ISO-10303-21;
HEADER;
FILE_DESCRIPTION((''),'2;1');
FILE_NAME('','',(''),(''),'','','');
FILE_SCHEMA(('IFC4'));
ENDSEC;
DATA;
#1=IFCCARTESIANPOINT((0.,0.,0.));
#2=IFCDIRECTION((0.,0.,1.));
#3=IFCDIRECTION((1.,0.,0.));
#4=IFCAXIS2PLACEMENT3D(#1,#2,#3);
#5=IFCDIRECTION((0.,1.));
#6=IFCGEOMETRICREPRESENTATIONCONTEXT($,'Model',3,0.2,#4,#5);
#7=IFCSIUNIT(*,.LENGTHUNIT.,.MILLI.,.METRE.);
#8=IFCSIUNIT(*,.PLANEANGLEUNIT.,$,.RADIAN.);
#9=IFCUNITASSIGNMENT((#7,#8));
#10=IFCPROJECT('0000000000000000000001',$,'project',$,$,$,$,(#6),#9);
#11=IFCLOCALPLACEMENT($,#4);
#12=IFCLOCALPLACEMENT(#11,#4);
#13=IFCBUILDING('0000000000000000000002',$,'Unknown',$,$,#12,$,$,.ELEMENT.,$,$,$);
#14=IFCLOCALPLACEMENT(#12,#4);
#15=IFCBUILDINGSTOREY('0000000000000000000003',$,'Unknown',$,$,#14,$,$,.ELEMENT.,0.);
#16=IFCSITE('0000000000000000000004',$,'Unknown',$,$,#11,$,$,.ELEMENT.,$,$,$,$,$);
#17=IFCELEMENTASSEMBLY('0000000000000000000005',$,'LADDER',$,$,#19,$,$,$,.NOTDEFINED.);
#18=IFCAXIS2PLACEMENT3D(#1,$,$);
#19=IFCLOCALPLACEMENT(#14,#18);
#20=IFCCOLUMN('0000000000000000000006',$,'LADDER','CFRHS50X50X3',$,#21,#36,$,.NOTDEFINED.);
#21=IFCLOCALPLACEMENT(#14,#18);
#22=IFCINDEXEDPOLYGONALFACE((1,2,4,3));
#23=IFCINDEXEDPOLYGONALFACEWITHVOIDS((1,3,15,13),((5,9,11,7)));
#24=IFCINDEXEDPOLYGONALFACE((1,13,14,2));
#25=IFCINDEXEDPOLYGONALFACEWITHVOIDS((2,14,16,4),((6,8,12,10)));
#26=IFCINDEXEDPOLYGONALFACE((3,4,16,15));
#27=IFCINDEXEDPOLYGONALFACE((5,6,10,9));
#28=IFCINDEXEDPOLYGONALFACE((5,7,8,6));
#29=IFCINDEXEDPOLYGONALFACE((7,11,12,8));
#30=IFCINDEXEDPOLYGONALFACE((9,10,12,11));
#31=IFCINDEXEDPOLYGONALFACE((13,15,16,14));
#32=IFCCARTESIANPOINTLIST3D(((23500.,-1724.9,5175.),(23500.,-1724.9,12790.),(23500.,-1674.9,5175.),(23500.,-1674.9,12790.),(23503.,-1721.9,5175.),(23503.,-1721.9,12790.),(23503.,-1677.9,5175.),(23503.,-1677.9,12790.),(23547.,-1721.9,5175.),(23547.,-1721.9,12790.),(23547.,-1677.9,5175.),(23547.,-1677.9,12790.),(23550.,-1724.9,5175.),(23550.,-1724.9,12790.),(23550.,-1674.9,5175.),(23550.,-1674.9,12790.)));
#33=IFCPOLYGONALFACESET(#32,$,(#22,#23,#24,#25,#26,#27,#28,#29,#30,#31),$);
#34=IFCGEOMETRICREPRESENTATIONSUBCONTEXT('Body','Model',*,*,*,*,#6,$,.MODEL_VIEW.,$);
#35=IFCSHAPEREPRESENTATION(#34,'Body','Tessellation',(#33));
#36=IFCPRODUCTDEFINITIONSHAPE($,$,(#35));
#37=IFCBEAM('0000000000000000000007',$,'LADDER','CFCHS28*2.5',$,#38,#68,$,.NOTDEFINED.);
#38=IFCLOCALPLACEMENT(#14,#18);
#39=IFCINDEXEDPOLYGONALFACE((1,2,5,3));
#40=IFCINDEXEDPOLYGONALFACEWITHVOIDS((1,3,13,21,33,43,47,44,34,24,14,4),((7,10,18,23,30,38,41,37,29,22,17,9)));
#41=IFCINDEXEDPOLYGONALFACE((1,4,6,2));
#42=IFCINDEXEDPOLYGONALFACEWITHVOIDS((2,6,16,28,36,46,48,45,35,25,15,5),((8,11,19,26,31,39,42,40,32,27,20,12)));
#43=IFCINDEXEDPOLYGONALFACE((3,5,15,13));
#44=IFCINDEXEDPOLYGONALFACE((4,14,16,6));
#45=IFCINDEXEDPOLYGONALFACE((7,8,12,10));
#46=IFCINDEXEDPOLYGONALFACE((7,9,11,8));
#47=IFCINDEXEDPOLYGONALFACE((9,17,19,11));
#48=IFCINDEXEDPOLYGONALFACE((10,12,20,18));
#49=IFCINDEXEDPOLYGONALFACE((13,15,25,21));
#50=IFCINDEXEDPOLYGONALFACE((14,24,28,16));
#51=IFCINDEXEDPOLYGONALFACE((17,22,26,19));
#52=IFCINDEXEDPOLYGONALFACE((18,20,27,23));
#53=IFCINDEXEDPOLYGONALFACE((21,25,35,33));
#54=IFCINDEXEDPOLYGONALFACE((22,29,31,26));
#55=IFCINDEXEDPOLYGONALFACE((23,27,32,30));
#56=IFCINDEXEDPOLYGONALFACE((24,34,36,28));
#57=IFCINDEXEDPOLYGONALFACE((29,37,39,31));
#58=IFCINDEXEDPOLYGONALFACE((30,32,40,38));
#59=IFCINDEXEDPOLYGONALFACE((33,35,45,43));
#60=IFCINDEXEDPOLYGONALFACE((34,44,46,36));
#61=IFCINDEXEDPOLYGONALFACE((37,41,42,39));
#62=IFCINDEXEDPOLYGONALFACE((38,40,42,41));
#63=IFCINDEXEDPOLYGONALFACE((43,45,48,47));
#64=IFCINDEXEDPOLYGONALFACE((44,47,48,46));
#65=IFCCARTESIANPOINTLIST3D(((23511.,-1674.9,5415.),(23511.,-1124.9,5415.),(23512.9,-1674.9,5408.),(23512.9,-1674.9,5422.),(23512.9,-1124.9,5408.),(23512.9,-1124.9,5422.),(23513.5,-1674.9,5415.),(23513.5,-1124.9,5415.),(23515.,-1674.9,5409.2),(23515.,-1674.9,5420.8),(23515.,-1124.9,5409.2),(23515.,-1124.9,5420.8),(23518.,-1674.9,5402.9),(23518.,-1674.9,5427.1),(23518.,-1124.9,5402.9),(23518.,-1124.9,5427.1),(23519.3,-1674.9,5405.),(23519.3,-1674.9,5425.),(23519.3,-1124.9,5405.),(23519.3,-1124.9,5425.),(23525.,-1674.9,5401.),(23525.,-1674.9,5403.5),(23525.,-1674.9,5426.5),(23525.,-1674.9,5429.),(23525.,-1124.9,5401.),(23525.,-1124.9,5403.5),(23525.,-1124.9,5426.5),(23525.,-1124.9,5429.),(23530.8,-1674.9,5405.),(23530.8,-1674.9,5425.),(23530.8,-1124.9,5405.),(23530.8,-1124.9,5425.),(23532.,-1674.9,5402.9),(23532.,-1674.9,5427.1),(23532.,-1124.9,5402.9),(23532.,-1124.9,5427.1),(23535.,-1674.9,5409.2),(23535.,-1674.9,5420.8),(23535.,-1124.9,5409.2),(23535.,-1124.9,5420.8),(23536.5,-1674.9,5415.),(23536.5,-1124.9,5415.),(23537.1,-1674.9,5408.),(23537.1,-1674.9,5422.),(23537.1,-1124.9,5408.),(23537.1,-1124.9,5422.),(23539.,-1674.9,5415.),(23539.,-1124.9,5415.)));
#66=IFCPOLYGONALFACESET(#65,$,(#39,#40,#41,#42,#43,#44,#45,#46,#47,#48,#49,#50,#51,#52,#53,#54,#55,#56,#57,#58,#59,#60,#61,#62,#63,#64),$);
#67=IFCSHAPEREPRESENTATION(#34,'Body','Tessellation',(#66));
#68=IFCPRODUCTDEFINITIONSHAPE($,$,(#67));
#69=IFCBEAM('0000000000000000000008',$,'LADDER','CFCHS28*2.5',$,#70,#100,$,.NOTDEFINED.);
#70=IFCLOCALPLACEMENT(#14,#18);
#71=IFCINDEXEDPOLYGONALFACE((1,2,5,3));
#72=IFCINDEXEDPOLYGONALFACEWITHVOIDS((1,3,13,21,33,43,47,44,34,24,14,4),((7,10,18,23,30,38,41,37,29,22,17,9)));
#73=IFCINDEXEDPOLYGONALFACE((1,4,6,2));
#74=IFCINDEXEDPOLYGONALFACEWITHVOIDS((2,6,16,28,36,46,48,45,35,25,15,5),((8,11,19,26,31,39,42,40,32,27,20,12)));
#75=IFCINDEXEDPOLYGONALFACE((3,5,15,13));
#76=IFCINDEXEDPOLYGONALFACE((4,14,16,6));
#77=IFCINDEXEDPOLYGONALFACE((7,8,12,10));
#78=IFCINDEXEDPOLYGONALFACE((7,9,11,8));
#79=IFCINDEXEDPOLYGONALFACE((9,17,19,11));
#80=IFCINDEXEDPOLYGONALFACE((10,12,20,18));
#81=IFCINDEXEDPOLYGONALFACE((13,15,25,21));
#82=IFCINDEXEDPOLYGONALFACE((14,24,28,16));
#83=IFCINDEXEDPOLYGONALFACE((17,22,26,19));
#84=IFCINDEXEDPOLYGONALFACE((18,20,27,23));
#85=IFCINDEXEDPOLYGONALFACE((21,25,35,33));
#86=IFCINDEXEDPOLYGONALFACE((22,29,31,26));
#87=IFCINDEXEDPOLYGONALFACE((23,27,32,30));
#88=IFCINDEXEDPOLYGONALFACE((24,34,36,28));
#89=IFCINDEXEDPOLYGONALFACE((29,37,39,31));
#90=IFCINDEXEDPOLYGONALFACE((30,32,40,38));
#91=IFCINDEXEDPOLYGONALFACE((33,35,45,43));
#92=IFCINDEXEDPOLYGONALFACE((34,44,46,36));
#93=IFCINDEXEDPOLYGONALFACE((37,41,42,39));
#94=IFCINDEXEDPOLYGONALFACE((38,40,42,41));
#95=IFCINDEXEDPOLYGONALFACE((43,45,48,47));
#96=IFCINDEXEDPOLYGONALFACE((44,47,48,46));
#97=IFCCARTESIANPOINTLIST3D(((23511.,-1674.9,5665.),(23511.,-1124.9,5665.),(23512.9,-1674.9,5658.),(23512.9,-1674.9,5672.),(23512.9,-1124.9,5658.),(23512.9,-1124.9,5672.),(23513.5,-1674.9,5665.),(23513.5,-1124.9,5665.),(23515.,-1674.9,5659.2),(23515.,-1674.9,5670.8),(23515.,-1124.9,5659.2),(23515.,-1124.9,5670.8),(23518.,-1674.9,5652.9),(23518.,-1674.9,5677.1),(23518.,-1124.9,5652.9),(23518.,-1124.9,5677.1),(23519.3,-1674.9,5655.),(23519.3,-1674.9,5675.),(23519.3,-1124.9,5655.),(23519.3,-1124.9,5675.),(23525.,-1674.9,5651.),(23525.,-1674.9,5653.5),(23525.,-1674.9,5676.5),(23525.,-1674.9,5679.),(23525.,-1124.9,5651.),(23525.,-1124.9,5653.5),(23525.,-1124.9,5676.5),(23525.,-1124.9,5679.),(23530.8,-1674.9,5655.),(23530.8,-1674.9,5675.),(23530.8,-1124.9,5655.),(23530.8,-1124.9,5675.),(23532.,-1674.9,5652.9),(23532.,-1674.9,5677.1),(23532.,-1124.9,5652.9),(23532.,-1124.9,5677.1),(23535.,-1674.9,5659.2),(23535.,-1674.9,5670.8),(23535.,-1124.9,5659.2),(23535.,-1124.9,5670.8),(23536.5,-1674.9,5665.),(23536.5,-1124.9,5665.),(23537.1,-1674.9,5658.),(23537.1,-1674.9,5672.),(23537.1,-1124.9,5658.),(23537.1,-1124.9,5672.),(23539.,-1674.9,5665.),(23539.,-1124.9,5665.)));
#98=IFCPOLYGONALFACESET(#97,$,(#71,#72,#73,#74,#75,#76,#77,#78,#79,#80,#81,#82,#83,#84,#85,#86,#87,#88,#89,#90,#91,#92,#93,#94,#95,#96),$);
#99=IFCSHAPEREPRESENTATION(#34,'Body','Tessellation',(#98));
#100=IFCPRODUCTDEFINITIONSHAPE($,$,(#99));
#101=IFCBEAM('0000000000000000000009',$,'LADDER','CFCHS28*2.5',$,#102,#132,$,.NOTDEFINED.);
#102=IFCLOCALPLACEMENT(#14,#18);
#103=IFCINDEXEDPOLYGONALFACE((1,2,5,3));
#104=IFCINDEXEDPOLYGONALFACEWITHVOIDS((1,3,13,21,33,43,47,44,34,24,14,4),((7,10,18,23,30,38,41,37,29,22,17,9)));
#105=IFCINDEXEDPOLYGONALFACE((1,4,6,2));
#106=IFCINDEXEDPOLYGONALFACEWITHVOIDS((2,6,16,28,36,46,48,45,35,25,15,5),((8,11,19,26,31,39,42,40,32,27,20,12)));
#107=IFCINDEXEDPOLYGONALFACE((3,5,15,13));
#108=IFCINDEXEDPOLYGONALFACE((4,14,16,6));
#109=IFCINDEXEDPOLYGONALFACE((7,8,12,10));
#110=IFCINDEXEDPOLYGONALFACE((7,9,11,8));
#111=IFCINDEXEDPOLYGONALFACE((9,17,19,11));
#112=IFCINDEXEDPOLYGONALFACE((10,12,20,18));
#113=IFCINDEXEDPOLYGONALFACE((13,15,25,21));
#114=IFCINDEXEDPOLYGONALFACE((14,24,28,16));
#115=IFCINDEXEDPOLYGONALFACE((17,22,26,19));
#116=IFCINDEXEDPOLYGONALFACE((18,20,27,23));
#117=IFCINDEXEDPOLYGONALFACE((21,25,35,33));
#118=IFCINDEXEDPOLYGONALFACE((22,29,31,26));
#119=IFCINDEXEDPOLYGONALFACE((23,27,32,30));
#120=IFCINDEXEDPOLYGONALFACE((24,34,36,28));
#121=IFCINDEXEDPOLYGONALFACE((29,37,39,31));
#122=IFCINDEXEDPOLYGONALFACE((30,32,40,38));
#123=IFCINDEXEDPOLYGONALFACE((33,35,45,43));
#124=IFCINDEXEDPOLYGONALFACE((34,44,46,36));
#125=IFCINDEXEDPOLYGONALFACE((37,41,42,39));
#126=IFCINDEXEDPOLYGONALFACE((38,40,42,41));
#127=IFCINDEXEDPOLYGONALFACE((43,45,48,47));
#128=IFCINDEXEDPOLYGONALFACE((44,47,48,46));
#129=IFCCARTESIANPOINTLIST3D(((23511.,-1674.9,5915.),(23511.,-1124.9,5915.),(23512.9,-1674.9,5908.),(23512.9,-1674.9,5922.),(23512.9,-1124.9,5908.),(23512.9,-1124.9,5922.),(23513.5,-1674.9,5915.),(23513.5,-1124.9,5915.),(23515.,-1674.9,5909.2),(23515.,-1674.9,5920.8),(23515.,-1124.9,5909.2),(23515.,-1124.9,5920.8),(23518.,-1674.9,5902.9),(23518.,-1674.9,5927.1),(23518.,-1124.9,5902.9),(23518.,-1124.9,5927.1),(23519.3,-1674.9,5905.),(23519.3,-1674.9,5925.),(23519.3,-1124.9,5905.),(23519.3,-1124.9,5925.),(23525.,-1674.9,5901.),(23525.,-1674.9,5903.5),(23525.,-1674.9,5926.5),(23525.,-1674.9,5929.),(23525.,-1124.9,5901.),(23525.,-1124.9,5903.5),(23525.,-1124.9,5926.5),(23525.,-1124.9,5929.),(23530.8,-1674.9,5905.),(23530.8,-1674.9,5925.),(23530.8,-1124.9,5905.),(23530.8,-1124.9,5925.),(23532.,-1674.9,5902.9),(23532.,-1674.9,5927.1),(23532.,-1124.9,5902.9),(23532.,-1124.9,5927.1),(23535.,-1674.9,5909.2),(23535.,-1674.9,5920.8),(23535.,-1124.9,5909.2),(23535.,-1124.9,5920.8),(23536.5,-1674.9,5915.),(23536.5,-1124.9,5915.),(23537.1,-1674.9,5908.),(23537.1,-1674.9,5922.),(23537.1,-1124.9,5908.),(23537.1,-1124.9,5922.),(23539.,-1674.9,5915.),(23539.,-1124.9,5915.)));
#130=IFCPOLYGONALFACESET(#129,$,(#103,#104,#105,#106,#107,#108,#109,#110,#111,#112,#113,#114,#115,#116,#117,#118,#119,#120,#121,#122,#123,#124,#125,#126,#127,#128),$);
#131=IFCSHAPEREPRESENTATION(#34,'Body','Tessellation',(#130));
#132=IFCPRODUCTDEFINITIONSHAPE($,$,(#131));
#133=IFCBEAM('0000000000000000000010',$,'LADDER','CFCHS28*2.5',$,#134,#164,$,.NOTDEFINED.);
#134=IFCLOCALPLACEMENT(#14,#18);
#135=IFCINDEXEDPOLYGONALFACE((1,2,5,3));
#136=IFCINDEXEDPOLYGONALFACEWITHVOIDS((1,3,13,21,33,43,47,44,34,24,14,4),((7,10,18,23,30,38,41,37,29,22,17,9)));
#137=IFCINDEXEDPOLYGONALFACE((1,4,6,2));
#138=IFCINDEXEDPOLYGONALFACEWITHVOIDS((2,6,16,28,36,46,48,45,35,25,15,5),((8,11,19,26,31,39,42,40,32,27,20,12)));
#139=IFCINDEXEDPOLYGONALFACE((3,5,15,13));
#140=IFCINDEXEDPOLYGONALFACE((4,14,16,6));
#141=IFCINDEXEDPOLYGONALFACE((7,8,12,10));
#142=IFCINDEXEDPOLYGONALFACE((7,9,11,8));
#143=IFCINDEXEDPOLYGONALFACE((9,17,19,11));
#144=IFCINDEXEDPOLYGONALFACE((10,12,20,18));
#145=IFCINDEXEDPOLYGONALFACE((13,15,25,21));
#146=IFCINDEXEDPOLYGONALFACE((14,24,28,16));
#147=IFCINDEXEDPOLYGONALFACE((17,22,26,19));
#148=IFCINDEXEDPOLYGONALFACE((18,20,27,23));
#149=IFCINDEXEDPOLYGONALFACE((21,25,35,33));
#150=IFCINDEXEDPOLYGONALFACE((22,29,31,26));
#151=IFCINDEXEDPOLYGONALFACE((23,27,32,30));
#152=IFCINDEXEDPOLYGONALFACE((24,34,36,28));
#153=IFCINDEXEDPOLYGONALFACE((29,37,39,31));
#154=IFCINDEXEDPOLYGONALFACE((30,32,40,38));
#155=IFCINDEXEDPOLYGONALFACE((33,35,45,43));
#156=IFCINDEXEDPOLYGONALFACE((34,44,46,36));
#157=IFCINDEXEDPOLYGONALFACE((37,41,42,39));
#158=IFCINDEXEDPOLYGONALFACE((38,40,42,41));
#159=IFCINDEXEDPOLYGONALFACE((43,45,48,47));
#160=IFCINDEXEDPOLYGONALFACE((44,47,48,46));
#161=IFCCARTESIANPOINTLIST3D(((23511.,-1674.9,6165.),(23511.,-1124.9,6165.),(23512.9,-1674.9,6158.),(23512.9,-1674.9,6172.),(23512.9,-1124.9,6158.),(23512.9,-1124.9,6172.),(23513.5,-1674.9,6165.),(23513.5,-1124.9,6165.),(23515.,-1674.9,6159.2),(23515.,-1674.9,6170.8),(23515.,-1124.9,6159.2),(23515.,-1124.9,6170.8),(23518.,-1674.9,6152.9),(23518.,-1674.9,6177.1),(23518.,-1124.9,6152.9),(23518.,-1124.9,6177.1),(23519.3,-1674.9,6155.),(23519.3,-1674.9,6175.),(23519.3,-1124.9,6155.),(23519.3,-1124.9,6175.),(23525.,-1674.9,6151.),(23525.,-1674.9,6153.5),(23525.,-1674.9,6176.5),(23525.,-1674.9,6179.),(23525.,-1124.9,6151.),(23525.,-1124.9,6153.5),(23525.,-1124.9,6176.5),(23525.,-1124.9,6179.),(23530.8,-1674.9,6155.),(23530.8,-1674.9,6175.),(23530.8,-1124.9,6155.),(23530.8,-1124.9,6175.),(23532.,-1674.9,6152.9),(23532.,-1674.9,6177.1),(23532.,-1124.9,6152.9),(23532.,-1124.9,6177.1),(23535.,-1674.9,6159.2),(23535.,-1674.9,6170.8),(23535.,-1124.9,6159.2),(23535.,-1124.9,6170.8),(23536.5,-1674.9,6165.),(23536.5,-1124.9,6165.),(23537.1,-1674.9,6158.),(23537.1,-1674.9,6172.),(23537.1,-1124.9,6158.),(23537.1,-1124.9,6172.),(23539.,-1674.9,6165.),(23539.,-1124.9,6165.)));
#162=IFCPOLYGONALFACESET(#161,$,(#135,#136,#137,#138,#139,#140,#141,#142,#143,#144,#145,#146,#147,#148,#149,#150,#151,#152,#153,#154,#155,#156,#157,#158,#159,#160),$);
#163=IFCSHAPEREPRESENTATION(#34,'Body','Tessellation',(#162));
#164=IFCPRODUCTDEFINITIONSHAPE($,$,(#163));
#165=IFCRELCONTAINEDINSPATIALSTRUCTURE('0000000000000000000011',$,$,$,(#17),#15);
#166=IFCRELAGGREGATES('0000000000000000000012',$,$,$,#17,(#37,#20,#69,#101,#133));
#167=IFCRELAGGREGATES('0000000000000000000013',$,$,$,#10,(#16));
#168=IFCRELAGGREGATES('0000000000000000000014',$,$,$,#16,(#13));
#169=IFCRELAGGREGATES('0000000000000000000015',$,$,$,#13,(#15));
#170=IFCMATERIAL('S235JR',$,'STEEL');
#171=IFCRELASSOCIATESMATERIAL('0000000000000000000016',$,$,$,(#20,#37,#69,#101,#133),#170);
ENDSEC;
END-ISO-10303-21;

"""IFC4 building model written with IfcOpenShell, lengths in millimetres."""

from ifc_helpers import new_model, si_unit, direction, frame, origin_with_axes, place, context, subcontext, project, spatial, line, indexed_curve, outline, extrude, material, element, aggregate, save


model = new_model("IFC4")

# Units and contexts
model_context = context("Model", 3, precision=0.2, world=origin_with_axes(), true_north=direction((0.0, 1.0)))
body_context = subcontext(model_context, "Body", "Model", "MODEL_VIEW")
ifc_project = project(units=[si_unit("LENGTHUNIT", "METRE", prefix="MILLI"), si_unit("PLANEANGLEUNIT", "RADIAN")], contexts=[model_context])

# Site, building, storey
site_placement = place(None, origin_with_axes())
site = spatial("IfcSite", under=ifc_project, at=site_placement, Name="Unknown", CompositionType="ELEMENT")
building_placement = place(site_placement, origin_with_axes())
building = spatial("IfcBuilding", under=site, at=building_placement, Name="Unknown", CompositionType="ELEMENT")
storey_placement = place(building_placement, origin_with_axes())
storey = spatial("IfcBuildingStorey", under=building, at=storey_placement, Name="Unknown", CompositionType="ELEMENT", Elevation=0.0)

# Element assembly, column, beams
assembly_1_placement = place(storey_placement, frame((23525.0, -1699.9, 5175.0), z_axis=(0.0, 1.0, 0.0), x_axis=(0.0, 0.0, 1.0)))
assembly_1 = element("IfcElementAssembly", 1, at=assembly_1_placement, inside=storey, Name="LADDER", PredefinedType="NOTDEFINED")
ifc_material_1 = material(Name="S235JR", Category="STEEL")
column_placement = place(assembly_1_placement, origin_with_axes())
column = element("IfcColumn", 2, at=column_placement, material=ifc_material_1, Name="LADDER", Description="CFRHS50X50X3", PredefinedType="NOTDEFINED", context=body_context, shape_type="SolidModel", body=[
    extrude(outline(indexed_curve([(-25.0, -25.0), (25.0, -25.0), (25.0, 25.0), (-25.0, 25.0)], segments=[line(1, 2, 3, 4, 1)]), holes=[indexed_curve([(-22.0, -22.0), (-22.0, 22.0), (22.0, 22.0), (22.0, -22.0)], segments=[line(1, 2, 3, 4, 1)])]), frame((0.0, 0.0, 0.0), z_axis=(-1.0, 0.0, 0.0), x_axis=(0.0, 0.0, 1.0)), (0.0, 0.0, -1.0), 7615.0),
])
beam_1_placement = place(assembly_1_placement, frame((240.0, 0.0, 25.0), z_axis=(0.0, -1.0, 0.0), x_axis=(0.0, 0.0, 1.0)))
beam_1 = element("IfcBeam", 3, at=beam_1_placement, material=ifc_material_1, Name="LADDER", Description="CFCHS28*2.5", PredefinedType="NOTDEFINED", context=body_context, shape_type="SolidModel", body=[
    extrude(outline(indexed_curve([(14.0, 0.0), (12.1, 7.0), (7.0, 12.1), (0.0, 14.0), (-7.0, 12.1), (-12.1, 7.0), (-14.0, 0.0), (-12.1, -7.0), (-7.0, -12.1), (0.0, -14.0), (7.0, -12.1), (12.1, -7.0)], segments=[line(1, 2, 3, 4, 5, 6, 7, 8, 9, 10, 11, 12, 1)]), holes=[indexed_curve([(11.5, 0.0), (10.0, -5.8), (5.8, -10.0), (0.0, -11.5), (-5.8, -10.0), (-10.0, -5.8), (-11.5, 0.0), (-10.0, 5.8), (-5.8, 10.0), (0.0, 11.5), (5.8, 10.0), (10.0, 5.8)], segments=[line(1, 2, 3, 4, 5, 6, 7, 8, 9, 10, 11, 12, 1)])]), frame((0.0, 0.0, 0.0), z_axis=(-1.0, 0.0, 0.0), x_axis=(0.0, 0.0, 1.0)), (0.0, 0.0, -1.0), 550.0),
])
beam_2_placement = place(assembly_1_placement, frame((490.0, 0.0, 25.0), z_axis=(0.0, -1.0, 0.0), x_axis=(0.0, 0.0, 1.0)))
beam_2 = element("IfcBeam", 4, at=beam_2_placement, material=ifc_material_1, Name="LADDER", Description="CFCHS28*2.5", PredefinedType="NOTDEFINED", context=body_context, shape_type="SolidModel", body=[
    extrude(outline(indexed_curve([(14.0, 0.0), (12.1, 7.0), (7.0, 12.1), (0.0, 14.0), (-7.0, 12.1), (-12.1, 7.0), (-14.0, 0.0), (-12.1, -7.0), (-7.0, -12.1), (0.0, -14.0), (7.0, -12.1), (12.1, -7.0)], segments=[line(1, 2, 3, 4, 5, 6, 7, 8, 9, 10, 11, 12, 1)]), holes=[indexed_curve([(11.5, 0.0), (10.0, -5.8), (5.8, -10.0), (0.0, -11.5), (-5.8, -10.0), (-10.0, -5.8), (-11.5, 0.0), (-10.0, 5.8), (-5.8, 10.0), (0.0, 11.5), (5.8, 10.0), (10.0, 5.8)], segments=[line(1, 2, 3, 4, 5, 6, 7, 8, 9, 10, 11, 12, 1)])]), frame((0.0, 0.0, 0.0), z_axis=(-1.0, 0.0, 0.0), x_axis=(0.0, 0.0, 1.0)), (0.0, 0.0, -1.0), 550.0),
])
beam_3_placement = place(assembly_1_placement, frame((740.0, 0.0, 25.0), z_axis=(0.0, -1.0, 0.0), x_axis=(0.0, 0.0, 1.0)))
beam_3 = element("IfcBeam", 5, at=beam_3_placement, material=ifc_material_1, Name="LADDER", Description="CFCHS28*2.5", PredefinedType="NOTDEFINED", context=body_context, shape_type="SolidModel", body=[
    extrude(outline(indexed_curve([(14.0, 0.0), (12.1, 7.0), (7.0, 12.1), (0.0, 14.0), (-7.0, 12.1), (-12.1, 7.0), (-14.0, 0.0), (-12.1, -7.0), (-7.0, -12.1), (0.0, -14.0), (7.0, -12.1), (12.1, -7.0)], segments=[line(1, 2, 3, 4, 5, 6, 7, 8, 9, 10, 11, 12, 1)]), holes=[indexed_curve([(11.5, 0.0), (10.0, -5.8), (5.8, -10.0), (0.0, -11.5), (-5.8, -10.0), (-10.0, -5.8), (-11.5, 0.0), (-10.0, 5.8), (-5.8, 10.0), (0.0, 11.5), (5.8, 10.0), (10.0, 5.8)], segments=[line(1, 2, 3, 4, 5, 6, 7, 8, 9, 10, 11, 12, 1)])]), frame((0.0, 0.0, 0.0), z_axis=(-1.0, 0.0, 0.0), x_axis=(0.0, 0.0, 1.0)), (0.0, 0.0, -1.0), 550.0),
])
beam_4_placement = place(assembly_1_placement, frame((990.0, 0.0, 25.0), z_axis=(0.0, -1.0, 0.0), x_axis=(0.0, 0.0, 1.0)))
beam_4 = element("IfcBeam", 6, at=beam_4_placement, material=ifc_material_1, Name="LADDER", Description="CFCHS28*2.5", PredefinedType="NOTDEFINED", context=body_context, shape_type="SolidModel", body=[
    extrude(outline(indexed_curve([(14.0, 0.0), (12.1, 7.0), (7.0, 12.1), (0.0, 14.0), (-7.0, 12.1), (-12.1, 7.0), (-14.0, 0.0), (-12.1, -7.0), (-7.0, -12.1), (0.0, -14.0), (7.0, -12.1), (12.1, -7.0)], segments=[line(1, 2, 3, 4, 5, 6, 7, 8, 9, 10, 11, 12, 1)]), holes=[indexed_curve([(11.5, 0.0), (10.0, -5.8), (5.8, -10.0), (0.0, -11.5), (-5.8, -10.0), (-10.0, -5.8), (-11.5, 0.0), (-10.0, 5.8), (-5.8, 10.0), (0.0, 11.5), (5.8, 10.0), (10.0, 5.8)], segments=[line(1, 2, 3, 4, 5, 6, 7, 8, 9, 10, 11, 12, 1)])]), frame((0.0, 0.0, 0.0), z_axis=(-1.0, 0.0, 0.0), x_axis=(0.0, 0.0, 1.0)), (0.0, 0.0, -1.0), 550.0),
])

aggregate(assembly_1, [beam_1, column, beam_2, beam_3, beam_4])

save(model, "model.ifc")
